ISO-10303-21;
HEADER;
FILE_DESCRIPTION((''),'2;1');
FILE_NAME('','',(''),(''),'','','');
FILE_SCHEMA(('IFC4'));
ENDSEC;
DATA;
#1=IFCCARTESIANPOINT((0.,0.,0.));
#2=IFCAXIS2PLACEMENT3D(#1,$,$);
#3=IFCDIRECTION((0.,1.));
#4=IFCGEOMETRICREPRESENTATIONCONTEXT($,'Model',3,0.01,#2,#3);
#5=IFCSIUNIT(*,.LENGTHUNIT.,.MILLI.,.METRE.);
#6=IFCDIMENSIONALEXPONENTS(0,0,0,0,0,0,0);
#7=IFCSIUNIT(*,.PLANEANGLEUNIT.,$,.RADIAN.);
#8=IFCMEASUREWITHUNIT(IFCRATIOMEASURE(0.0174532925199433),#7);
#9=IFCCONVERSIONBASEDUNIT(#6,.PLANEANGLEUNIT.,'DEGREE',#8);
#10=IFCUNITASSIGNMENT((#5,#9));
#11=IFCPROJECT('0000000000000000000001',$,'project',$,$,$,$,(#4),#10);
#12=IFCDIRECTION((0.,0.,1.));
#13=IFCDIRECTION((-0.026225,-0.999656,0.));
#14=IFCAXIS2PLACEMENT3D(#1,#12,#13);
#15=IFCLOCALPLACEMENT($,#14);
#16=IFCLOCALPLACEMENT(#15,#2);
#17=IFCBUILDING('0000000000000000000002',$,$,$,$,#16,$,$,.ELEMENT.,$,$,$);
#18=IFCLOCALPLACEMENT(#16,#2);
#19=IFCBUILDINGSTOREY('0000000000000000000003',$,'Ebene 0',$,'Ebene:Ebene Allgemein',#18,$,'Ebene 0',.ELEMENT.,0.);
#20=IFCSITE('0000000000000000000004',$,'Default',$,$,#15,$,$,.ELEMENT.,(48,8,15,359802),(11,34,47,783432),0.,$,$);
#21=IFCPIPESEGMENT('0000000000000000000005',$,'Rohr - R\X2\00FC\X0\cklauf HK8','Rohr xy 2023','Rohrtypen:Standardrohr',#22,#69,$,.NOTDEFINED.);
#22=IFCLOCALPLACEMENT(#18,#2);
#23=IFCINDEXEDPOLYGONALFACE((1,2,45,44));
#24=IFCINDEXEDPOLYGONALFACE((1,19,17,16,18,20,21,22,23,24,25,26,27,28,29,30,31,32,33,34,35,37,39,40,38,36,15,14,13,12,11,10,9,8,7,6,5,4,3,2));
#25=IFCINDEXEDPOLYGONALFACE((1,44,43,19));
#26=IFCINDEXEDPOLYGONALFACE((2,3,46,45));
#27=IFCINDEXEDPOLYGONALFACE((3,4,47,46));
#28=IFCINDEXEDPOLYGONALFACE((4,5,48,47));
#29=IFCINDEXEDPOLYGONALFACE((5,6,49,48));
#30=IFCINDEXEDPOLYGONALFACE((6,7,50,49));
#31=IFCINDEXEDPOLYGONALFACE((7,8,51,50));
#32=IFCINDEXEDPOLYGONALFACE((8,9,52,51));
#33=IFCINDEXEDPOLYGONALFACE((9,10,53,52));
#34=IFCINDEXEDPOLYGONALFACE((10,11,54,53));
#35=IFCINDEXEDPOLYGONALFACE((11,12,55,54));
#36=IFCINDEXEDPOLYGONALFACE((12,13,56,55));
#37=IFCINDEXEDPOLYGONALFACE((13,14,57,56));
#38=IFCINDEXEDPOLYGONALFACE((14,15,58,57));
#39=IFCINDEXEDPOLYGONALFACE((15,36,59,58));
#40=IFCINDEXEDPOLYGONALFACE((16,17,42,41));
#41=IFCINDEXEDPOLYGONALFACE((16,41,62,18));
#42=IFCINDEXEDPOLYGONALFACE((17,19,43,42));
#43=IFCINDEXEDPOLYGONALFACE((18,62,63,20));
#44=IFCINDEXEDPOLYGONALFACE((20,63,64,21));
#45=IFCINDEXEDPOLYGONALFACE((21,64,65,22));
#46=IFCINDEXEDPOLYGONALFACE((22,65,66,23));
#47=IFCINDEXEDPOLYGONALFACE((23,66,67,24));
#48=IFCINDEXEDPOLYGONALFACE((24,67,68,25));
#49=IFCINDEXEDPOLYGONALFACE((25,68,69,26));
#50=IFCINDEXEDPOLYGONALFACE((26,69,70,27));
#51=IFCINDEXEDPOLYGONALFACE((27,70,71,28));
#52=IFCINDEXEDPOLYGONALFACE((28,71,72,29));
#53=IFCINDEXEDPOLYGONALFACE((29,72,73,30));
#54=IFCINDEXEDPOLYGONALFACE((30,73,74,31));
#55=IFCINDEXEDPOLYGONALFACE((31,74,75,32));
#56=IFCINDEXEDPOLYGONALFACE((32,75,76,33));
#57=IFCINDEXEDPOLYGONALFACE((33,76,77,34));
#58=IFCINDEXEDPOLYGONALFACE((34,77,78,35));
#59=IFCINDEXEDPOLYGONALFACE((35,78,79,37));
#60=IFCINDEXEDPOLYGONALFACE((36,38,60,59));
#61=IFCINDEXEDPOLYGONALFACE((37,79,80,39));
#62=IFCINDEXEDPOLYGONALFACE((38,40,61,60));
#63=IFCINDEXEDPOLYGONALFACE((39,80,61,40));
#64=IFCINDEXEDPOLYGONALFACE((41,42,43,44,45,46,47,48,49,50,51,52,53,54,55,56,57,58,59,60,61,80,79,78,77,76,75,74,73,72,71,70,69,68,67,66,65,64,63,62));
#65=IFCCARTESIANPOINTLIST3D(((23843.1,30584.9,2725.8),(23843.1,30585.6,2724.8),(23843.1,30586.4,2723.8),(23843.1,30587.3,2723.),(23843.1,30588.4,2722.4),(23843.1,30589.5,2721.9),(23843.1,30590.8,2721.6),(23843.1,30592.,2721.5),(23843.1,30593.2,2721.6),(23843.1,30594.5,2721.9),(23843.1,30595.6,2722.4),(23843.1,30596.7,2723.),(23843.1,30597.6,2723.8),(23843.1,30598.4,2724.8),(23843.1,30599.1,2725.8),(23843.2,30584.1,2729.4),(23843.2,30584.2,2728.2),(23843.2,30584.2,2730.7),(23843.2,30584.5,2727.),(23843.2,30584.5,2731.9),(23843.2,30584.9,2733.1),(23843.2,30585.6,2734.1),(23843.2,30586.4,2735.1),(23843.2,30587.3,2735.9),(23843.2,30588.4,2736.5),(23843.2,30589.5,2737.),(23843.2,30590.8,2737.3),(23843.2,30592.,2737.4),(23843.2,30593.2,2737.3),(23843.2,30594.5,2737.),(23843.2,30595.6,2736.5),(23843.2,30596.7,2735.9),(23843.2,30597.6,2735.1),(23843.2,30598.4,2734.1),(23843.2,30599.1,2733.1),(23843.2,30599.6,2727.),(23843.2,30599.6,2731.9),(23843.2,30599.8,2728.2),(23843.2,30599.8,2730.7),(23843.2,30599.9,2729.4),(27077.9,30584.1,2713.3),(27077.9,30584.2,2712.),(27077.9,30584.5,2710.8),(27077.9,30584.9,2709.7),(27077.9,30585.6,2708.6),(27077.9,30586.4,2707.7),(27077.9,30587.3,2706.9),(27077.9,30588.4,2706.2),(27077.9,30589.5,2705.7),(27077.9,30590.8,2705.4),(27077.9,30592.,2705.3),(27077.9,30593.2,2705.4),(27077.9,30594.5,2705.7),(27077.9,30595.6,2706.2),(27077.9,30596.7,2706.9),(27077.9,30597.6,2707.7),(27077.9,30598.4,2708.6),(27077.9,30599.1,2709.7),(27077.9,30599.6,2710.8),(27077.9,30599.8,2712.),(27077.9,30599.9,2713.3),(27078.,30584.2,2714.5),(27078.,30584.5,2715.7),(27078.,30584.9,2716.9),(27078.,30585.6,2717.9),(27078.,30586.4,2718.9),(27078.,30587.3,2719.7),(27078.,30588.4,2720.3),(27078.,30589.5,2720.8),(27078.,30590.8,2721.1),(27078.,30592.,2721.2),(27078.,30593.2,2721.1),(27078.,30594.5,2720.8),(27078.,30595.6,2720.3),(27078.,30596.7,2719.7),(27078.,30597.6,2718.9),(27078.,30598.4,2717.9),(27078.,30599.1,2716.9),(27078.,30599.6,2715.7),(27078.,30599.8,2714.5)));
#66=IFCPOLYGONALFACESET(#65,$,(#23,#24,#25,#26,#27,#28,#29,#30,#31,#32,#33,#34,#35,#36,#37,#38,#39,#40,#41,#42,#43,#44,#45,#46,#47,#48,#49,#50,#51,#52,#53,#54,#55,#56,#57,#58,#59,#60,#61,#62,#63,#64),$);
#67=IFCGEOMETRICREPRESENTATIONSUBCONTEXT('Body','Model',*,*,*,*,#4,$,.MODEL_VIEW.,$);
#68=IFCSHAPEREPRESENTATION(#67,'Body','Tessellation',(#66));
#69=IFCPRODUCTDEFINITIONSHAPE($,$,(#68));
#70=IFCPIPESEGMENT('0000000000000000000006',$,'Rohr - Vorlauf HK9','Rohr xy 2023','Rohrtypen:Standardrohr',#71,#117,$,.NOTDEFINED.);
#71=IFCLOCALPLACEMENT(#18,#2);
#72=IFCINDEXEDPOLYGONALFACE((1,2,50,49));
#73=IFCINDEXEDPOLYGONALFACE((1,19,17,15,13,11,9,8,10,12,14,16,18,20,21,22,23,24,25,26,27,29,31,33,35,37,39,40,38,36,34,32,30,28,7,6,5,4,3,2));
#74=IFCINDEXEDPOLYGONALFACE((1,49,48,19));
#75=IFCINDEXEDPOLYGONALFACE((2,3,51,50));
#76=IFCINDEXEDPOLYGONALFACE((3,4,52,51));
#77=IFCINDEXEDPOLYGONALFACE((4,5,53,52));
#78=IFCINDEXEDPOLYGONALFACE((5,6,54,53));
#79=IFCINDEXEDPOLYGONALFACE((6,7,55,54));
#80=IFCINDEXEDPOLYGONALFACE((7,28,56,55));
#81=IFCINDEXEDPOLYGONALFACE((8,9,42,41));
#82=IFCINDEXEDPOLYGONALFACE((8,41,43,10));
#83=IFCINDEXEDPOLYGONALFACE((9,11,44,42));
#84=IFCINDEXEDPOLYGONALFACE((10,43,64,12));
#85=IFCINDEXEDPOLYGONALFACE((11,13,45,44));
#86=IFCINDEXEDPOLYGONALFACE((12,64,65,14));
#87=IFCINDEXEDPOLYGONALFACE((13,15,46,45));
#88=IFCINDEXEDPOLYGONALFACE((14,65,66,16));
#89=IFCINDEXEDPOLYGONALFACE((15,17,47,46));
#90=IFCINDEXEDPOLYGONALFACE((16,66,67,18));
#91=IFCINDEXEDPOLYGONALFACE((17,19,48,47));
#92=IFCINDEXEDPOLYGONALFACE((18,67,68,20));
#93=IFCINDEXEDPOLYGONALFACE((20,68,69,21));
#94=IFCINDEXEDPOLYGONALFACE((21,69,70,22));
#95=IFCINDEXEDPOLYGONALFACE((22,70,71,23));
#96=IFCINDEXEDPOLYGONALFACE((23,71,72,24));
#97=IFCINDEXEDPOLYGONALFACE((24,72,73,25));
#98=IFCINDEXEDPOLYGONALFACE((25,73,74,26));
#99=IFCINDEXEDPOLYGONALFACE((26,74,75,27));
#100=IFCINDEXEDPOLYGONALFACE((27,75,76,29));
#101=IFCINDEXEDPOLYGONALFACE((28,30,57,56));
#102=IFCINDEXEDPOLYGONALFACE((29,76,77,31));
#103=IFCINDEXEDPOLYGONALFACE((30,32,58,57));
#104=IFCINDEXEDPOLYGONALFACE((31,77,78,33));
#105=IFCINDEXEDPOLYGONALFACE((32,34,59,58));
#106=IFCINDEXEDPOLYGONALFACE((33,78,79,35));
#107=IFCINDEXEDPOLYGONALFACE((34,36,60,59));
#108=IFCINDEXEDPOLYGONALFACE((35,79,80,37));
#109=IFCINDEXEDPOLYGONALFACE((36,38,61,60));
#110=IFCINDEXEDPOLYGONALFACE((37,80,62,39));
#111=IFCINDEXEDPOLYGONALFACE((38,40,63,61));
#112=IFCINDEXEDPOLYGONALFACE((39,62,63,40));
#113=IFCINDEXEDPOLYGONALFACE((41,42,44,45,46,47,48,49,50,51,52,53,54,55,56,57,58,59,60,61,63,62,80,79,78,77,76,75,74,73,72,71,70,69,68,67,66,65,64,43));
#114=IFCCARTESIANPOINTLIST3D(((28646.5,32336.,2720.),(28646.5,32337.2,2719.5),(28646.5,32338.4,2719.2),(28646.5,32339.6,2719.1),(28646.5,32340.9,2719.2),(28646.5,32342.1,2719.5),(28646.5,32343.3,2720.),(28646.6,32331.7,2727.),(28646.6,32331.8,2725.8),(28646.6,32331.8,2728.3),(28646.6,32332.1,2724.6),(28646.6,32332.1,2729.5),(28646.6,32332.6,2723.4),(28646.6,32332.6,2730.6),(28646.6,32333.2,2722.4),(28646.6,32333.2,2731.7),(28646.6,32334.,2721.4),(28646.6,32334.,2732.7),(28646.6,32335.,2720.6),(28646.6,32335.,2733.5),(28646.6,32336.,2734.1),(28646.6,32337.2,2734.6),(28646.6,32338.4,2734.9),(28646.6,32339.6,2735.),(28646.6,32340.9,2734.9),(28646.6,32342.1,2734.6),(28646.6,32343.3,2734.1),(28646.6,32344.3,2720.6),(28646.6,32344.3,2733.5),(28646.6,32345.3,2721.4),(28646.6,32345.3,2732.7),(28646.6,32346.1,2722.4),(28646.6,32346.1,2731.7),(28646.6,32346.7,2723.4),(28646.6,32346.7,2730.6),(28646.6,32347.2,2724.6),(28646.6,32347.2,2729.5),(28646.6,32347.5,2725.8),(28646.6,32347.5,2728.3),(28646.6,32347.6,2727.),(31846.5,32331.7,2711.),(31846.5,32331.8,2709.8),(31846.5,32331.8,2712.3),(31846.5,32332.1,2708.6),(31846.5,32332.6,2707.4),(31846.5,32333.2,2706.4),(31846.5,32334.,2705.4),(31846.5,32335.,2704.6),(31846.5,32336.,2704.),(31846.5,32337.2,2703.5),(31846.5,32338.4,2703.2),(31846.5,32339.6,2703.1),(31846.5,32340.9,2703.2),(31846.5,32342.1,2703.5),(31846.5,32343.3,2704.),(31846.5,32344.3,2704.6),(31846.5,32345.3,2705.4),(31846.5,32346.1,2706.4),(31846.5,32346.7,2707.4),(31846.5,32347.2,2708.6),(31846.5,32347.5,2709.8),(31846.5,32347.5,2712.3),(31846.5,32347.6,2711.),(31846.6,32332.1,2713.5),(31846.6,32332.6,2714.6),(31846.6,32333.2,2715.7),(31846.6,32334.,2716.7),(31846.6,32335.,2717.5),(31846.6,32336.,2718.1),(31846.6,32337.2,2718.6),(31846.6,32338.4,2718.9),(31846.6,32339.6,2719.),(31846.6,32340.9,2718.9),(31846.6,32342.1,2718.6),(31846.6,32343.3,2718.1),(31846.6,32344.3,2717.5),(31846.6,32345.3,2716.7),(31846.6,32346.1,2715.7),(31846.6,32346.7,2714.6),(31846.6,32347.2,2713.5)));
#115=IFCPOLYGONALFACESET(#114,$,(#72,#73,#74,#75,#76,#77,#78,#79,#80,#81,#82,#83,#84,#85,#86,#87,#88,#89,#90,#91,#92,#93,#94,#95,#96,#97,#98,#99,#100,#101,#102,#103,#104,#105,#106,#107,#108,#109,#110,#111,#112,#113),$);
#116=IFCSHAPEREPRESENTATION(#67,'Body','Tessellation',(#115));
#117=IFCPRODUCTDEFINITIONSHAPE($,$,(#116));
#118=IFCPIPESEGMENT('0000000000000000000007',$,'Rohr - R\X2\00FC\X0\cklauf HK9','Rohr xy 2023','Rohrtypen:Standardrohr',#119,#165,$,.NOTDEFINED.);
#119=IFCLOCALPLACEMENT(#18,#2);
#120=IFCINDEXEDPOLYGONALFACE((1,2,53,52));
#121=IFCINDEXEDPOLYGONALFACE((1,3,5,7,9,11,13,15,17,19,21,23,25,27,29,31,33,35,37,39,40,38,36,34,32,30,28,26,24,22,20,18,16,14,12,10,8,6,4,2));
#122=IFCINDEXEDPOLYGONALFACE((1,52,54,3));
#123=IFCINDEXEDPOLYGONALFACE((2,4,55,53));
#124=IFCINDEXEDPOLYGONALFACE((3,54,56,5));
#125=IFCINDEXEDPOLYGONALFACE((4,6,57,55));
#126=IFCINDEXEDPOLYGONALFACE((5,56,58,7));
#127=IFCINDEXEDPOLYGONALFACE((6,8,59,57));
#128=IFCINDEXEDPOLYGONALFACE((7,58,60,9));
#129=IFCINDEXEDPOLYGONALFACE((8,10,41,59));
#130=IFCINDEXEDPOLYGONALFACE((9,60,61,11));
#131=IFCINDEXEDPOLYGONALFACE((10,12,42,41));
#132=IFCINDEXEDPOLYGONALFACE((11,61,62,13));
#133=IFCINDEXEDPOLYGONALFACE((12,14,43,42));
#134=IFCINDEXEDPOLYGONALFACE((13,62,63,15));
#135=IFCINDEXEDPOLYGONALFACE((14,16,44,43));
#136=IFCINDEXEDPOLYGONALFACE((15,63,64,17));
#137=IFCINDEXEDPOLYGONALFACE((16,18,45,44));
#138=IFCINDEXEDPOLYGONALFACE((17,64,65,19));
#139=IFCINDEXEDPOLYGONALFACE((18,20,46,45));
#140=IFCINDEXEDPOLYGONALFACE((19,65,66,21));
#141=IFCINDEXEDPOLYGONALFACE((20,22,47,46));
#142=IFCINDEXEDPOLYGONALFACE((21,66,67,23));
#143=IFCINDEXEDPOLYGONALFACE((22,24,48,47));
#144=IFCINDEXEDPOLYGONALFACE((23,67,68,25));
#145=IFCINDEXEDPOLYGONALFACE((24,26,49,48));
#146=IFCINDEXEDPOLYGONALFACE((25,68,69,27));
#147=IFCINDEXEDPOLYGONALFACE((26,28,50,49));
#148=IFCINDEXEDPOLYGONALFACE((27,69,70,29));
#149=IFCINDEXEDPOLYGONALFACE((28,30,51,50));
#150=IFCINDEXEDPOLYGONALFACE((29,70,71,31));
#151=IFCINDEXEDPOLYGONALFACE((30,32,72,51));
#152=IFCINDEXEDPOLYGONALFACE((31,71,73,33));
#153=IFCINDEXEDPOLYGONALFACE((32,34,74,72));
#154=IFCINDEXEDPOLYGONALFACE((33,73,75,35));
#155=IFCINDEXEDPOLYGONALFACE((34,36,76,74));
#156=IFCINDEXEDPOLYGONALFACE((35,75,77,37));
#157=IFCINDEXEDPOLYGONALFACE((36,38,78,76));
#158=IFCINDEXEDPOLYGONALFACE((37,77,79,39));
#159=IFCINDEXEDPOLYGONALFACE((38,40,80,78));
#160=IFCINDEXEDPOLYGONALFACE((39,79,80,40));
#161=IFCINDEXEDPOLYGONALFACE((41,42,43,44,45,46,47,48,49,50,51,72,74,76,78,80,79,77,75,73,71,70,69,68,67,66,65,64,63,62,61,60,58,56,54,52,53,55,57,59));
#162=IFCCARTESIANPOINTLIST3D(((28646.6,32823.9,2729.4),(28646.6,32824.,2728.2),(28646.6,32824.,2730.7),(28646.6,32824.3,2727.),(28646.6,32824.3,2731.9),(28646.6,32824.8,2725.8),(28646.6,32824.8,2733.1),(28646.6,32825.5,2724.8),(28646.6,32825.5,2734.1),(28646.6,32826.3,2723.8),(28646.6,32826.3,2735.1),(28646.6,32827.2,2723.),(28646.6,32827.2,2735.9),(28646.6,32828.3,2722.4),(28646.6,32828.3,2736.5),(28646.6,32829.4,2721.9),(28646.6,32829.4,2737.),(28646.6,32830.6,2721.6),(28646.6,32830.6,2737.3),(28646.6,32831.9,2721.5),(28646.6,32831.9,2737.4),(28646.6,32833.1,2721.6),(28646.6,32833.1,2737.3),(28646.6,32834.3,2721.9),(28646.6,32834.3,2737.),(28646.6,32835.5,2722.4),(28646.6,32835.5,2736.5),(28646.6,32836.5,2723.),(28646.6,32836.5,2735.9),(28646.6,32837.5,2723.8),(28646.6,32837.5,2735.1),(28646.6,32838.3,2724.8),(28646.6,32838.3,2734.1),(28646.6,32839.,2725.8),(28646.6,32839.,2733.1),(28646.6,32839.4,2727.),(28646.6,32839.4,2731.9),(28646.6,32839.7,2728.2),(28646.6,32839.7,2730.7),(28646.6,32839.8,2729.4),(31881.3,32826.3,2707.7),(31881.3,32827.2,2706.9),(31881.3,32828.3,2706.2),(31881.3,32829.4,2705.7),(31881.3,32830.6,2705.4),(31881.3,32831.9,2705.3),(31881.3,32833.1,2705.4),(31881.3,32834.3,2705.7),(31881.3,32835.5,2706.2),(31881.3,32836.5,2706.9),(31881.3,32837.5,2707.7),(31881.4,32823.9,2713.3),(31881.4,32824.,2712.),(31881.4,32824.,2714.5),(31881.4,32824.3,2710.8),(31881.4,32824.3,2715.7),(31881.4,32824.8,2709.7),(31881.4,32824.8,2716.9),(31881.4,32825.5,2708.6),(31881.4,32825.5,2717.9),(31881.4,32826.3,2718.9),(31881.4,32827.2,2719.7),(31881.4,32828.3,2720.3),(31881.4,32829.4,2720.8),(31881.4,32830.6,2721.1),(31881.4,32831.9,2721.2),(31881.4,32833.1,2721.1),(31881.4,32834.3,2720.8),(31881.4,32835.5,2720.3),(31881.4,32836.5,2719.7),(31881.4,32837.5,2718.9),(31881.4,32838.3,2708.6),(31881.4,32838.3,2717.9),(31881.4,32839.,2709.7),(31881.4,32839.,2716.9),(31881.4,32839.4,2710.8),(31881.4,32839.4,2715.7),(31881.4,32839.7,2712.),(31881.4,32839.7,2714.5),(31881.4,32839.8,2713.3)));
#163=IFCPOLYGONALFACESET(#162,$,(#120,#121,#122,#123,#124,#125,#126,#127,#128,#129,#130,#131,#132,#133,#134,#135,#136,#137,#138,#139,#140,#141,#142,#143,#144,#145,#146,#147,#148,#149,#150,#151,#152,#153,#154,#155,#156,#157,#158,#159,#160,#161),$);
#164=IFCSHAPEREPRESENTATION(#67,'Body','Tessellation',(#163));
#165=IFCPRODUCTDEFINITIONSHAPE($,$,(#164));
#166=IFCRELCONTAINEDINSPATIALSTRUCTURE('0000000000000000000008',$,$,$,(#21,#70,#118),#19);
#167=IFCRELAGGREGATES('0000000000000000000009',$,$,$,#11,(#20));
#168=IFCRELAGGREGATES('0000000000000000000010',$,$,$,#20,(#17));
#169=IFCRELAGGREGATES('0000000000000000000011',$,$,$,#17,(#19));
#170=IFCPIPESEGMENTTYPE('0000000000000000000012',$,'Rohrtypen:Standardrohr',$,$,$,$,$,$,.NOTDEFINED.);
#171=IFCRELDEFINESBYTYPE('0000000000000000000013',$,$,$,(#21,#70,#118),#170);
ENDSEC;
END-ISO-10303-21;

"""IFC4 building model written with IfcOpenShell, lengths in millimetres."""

from ifc_helpers import new_model, entity, si_unit, converted_unit, direction, frame, origin, place, context, subcontext, project, spatial, indexed_curve, outline, extrude, type_object, element, save


model = new_model("IFC4")

# Units and contexts
model_context = context("Model", 3, precision=0.01, world=origin(), true_north=direction((0.0, 1.0)))
body_context = subcontext(model_context, "Body", "Model", "MODEL_VIEW")
ifc_project = project(units=[si_unit("LENGTHUNIT", "METRE", prefix="MILLI"), converted_unit("PLANEANGLEUNIT", "DEGREE", entity("IfcRatioMeasure", 0.0174532925199433), si_unit("PLANEANGLEUNIT", "RADIAN"), dimensions=[0, 0, 0, 0, 0, 0, 0])], contexts=[model_context])

# Site, building, storey
site_placement = place(None, frame((0.0, 0.0, 0.0), z_axis=(0.0, 0.0, 1.0), x_axis=(-0.026225, -0.999656, 0.0)))
site = spatial("IfcSite", under=ifc_project, at=site_placement, Name="Default", CompositionType="ELEMENT", RefLatitude=(48, 8, 15, 359802), RefLongitude=(11, 34, 47, 783432), RefElevation=0.0)
building_placement = place(site_placement, origin())
building = spatial("IfcBuilding", under=site, at=building_placement, CompositionType="ELEMENT")
storey_placement = place(building_placement, origin())
storey = spatial("IfcBuildingStorey", under=building, at=storey_placement, Name="Ebene 0", ObjectType="Ebene:Ebene Allgemein", LongName="Ebene 0", CompositionType="ELEMENT", Elevation=0.0)

# Pipe segments
pipe_segment_type = type_object("IfcPipeSegmentType", Name="Rohrtypen:Standardrohr", PredefinedType="NOTDEFINED")
pipe_segment_1_placement = place(storey_placement, origin())
element("IfcPipeSegment", 1, at=pipe_segment_1_placement, inside=storey, type_object=pipe_segment_type, Name="Rohr - Rücklauf HK8", Description="Rohr xy 2023", ObjectType="Rohrtypen:Standardrohr", PredefinedType="NOTDEFINED", context=body_context, shape_type="SweptSolid", body=[
    extrude(outline(indexed_curve([(7.9, 0.0), (7.8, 1.2), (7.6, 2.5), (7.1, 3.6), (6.4, 4.7), (5.6, 5.6), (4.7, 6.4), (3.6, 7.1), (2.5, 7.6), (1.2, 7.8), (0.0, 7.9), (-1.2, 7.8), (-2.5, 7.6), (-3.6, 7.1), (-4.7, 6.4), (-5.6, 5.6), (-6.4, 4.7), (-7.1, 3.6), (-7.6, 2.5), (-7.8, 1.2), (-7.9, 0.0), (-7.8, -1.2), (-7.6, -2.5), (-7.1, -3.6), (-6.4, -4.7), (-5.6, -5.6), (-4.7, -6.4), (-3.6, -7.1), (-2.5, -7.6), (-1.2, -7.8), (0.0, -7.9), (1.2, -7.8), (2.5, -7.6), (3.6, -7.1), (4.7, -6.4), (5.6, -5.6), (6.4, -4.7), (7.1, -3.6), (7.6, -2.5), (7.8, -1.2), (7.9, 0.0)], self_intersect=False)), frame((27077.9, 30592.0, 2713.3), z_axis=(-0.999988, 0.0, 0.005), x_axis=(0.0, 1.0, 0.0)), (0.0, 0.0, 1.0), 3234.8),
])
pipe_segment_2_placement = place(storey_placement, origin())
element("IfcPipeSegment", 2, at=pipe_segment_2_placement, inside=storey, type_object=pipe_segment_type, Name="Rohr - Vorlauf HK9", Description="Rohr xy 2023", ObjectType="Rohrtypen:Standardrohr", PredefinedType="NOTDEFINED", context=body_context, shape_type="SweptSolid", body=[
    extrude(outline(indexed_curve([(7.9, 0.0), (7.8, 1.2), (7.6, 2.5), (7.1, 3.6), (6.4, 4.7), (5.6, 5.6), (4.7, 6.4), (3.6, 7.1), (2.5, 7.6), (1.2, 7.8), (0.0, 7.9), (-1.2, 7.8), (-2.5, 7.6), (-3.6, 7.1), (-4.7, 6.4), (-5.6, 5.6), (-6.4, 4.7), (-7.1, 3.6), (-7.6, 2.5), (-7.8, 1.2), (-7.9, 0.0), (-7.8, -1.2), (-7.6, -2.5), (-7.1, -3.6), (-6.4, -4.7), (-5.6, -5.6), (-4.7, -6.4), (-3.6, -7.1), (-2.5, -7.6), (-1.2, -7.8), (0.0, -7.9), (1.2, -7.8), (2.5, -7.6), (3.6, -7.1), (4.7, -6.4), (5.6, -5.6), (6.4, -4.7), (7.1, -3.6), (7.6, -2.5), (7.8, -1.2), (7.9, 0.0)], self_intersect=False)), frame((31846.5, 32339.6, 2711.0), z_axis=(-0.999988, 0.0, 0.005), x_axis=(0.0, 1.0, 0.0)), (0.0, 0.0, 1.0), 3200.0),
])
pipe_segment_3_placement = place(storey_placement, origin())
element("IfcPipeSegment", 3, at=pipe_segment_3_placement, inside=storey, type_object=pipe_segment_type, Name="Rohr - Rücklauf HK9", Description="Rohr xy 2023", ObjectType="Rohrtypen:Standardrohr", PredefinedType="NOTDEFINED", context=body_context, shape_type="SweptSolid", body=[
    extrude(outline(indexed_curve([(7.9, 0.0), (7.8, 1.2), (7.6, 2.5), (7.1, 3.6), (6.4, 4.7), (5.6, 5.6), (4.7, 6.4), (3.6, 7.1), (2.5, 7.6), (1.2, 7.8), (0.0, 7.9), (-1.2, 7.8), (-2.5, 7.6), (-3.6, 7.1), (-4.7, 6.4), (-5.6, 5.6), (-6.4, 4.7), (-7.1, 3.6), (-7.6, 2.5), (-7.8, 1.2), (-7.9, 0.0), (-7.8, -1.2), (-7.6, -2.5), (-7.1, -3.6), (-6.4, -4.7), (-5.6, -5.6), (-4.7, -6.4), (-3.6, -7.1), (-2.5, -7.6), (-1.2, -7.8), (0.0, -7.9), (1.2, -7.8), (2.5, -7.6), (3.6, -7.1), (4.7, -6.4), (5.6, -5.6), (6.4, -4.7), (7.1, -3.6), (7.6, -2.5), (7.8, -1.2), (7.9, 0.0)], self_intersect=False)), frame((31881.4, 32831.9, 2713.3), z_axis=(-0.999988, 0.0, 0.005), x_axis=(0.0, 1.0, 0.0)), (0.0, 0.0, 1.0), 3234.8),
])

save(model, "model.ifc")
